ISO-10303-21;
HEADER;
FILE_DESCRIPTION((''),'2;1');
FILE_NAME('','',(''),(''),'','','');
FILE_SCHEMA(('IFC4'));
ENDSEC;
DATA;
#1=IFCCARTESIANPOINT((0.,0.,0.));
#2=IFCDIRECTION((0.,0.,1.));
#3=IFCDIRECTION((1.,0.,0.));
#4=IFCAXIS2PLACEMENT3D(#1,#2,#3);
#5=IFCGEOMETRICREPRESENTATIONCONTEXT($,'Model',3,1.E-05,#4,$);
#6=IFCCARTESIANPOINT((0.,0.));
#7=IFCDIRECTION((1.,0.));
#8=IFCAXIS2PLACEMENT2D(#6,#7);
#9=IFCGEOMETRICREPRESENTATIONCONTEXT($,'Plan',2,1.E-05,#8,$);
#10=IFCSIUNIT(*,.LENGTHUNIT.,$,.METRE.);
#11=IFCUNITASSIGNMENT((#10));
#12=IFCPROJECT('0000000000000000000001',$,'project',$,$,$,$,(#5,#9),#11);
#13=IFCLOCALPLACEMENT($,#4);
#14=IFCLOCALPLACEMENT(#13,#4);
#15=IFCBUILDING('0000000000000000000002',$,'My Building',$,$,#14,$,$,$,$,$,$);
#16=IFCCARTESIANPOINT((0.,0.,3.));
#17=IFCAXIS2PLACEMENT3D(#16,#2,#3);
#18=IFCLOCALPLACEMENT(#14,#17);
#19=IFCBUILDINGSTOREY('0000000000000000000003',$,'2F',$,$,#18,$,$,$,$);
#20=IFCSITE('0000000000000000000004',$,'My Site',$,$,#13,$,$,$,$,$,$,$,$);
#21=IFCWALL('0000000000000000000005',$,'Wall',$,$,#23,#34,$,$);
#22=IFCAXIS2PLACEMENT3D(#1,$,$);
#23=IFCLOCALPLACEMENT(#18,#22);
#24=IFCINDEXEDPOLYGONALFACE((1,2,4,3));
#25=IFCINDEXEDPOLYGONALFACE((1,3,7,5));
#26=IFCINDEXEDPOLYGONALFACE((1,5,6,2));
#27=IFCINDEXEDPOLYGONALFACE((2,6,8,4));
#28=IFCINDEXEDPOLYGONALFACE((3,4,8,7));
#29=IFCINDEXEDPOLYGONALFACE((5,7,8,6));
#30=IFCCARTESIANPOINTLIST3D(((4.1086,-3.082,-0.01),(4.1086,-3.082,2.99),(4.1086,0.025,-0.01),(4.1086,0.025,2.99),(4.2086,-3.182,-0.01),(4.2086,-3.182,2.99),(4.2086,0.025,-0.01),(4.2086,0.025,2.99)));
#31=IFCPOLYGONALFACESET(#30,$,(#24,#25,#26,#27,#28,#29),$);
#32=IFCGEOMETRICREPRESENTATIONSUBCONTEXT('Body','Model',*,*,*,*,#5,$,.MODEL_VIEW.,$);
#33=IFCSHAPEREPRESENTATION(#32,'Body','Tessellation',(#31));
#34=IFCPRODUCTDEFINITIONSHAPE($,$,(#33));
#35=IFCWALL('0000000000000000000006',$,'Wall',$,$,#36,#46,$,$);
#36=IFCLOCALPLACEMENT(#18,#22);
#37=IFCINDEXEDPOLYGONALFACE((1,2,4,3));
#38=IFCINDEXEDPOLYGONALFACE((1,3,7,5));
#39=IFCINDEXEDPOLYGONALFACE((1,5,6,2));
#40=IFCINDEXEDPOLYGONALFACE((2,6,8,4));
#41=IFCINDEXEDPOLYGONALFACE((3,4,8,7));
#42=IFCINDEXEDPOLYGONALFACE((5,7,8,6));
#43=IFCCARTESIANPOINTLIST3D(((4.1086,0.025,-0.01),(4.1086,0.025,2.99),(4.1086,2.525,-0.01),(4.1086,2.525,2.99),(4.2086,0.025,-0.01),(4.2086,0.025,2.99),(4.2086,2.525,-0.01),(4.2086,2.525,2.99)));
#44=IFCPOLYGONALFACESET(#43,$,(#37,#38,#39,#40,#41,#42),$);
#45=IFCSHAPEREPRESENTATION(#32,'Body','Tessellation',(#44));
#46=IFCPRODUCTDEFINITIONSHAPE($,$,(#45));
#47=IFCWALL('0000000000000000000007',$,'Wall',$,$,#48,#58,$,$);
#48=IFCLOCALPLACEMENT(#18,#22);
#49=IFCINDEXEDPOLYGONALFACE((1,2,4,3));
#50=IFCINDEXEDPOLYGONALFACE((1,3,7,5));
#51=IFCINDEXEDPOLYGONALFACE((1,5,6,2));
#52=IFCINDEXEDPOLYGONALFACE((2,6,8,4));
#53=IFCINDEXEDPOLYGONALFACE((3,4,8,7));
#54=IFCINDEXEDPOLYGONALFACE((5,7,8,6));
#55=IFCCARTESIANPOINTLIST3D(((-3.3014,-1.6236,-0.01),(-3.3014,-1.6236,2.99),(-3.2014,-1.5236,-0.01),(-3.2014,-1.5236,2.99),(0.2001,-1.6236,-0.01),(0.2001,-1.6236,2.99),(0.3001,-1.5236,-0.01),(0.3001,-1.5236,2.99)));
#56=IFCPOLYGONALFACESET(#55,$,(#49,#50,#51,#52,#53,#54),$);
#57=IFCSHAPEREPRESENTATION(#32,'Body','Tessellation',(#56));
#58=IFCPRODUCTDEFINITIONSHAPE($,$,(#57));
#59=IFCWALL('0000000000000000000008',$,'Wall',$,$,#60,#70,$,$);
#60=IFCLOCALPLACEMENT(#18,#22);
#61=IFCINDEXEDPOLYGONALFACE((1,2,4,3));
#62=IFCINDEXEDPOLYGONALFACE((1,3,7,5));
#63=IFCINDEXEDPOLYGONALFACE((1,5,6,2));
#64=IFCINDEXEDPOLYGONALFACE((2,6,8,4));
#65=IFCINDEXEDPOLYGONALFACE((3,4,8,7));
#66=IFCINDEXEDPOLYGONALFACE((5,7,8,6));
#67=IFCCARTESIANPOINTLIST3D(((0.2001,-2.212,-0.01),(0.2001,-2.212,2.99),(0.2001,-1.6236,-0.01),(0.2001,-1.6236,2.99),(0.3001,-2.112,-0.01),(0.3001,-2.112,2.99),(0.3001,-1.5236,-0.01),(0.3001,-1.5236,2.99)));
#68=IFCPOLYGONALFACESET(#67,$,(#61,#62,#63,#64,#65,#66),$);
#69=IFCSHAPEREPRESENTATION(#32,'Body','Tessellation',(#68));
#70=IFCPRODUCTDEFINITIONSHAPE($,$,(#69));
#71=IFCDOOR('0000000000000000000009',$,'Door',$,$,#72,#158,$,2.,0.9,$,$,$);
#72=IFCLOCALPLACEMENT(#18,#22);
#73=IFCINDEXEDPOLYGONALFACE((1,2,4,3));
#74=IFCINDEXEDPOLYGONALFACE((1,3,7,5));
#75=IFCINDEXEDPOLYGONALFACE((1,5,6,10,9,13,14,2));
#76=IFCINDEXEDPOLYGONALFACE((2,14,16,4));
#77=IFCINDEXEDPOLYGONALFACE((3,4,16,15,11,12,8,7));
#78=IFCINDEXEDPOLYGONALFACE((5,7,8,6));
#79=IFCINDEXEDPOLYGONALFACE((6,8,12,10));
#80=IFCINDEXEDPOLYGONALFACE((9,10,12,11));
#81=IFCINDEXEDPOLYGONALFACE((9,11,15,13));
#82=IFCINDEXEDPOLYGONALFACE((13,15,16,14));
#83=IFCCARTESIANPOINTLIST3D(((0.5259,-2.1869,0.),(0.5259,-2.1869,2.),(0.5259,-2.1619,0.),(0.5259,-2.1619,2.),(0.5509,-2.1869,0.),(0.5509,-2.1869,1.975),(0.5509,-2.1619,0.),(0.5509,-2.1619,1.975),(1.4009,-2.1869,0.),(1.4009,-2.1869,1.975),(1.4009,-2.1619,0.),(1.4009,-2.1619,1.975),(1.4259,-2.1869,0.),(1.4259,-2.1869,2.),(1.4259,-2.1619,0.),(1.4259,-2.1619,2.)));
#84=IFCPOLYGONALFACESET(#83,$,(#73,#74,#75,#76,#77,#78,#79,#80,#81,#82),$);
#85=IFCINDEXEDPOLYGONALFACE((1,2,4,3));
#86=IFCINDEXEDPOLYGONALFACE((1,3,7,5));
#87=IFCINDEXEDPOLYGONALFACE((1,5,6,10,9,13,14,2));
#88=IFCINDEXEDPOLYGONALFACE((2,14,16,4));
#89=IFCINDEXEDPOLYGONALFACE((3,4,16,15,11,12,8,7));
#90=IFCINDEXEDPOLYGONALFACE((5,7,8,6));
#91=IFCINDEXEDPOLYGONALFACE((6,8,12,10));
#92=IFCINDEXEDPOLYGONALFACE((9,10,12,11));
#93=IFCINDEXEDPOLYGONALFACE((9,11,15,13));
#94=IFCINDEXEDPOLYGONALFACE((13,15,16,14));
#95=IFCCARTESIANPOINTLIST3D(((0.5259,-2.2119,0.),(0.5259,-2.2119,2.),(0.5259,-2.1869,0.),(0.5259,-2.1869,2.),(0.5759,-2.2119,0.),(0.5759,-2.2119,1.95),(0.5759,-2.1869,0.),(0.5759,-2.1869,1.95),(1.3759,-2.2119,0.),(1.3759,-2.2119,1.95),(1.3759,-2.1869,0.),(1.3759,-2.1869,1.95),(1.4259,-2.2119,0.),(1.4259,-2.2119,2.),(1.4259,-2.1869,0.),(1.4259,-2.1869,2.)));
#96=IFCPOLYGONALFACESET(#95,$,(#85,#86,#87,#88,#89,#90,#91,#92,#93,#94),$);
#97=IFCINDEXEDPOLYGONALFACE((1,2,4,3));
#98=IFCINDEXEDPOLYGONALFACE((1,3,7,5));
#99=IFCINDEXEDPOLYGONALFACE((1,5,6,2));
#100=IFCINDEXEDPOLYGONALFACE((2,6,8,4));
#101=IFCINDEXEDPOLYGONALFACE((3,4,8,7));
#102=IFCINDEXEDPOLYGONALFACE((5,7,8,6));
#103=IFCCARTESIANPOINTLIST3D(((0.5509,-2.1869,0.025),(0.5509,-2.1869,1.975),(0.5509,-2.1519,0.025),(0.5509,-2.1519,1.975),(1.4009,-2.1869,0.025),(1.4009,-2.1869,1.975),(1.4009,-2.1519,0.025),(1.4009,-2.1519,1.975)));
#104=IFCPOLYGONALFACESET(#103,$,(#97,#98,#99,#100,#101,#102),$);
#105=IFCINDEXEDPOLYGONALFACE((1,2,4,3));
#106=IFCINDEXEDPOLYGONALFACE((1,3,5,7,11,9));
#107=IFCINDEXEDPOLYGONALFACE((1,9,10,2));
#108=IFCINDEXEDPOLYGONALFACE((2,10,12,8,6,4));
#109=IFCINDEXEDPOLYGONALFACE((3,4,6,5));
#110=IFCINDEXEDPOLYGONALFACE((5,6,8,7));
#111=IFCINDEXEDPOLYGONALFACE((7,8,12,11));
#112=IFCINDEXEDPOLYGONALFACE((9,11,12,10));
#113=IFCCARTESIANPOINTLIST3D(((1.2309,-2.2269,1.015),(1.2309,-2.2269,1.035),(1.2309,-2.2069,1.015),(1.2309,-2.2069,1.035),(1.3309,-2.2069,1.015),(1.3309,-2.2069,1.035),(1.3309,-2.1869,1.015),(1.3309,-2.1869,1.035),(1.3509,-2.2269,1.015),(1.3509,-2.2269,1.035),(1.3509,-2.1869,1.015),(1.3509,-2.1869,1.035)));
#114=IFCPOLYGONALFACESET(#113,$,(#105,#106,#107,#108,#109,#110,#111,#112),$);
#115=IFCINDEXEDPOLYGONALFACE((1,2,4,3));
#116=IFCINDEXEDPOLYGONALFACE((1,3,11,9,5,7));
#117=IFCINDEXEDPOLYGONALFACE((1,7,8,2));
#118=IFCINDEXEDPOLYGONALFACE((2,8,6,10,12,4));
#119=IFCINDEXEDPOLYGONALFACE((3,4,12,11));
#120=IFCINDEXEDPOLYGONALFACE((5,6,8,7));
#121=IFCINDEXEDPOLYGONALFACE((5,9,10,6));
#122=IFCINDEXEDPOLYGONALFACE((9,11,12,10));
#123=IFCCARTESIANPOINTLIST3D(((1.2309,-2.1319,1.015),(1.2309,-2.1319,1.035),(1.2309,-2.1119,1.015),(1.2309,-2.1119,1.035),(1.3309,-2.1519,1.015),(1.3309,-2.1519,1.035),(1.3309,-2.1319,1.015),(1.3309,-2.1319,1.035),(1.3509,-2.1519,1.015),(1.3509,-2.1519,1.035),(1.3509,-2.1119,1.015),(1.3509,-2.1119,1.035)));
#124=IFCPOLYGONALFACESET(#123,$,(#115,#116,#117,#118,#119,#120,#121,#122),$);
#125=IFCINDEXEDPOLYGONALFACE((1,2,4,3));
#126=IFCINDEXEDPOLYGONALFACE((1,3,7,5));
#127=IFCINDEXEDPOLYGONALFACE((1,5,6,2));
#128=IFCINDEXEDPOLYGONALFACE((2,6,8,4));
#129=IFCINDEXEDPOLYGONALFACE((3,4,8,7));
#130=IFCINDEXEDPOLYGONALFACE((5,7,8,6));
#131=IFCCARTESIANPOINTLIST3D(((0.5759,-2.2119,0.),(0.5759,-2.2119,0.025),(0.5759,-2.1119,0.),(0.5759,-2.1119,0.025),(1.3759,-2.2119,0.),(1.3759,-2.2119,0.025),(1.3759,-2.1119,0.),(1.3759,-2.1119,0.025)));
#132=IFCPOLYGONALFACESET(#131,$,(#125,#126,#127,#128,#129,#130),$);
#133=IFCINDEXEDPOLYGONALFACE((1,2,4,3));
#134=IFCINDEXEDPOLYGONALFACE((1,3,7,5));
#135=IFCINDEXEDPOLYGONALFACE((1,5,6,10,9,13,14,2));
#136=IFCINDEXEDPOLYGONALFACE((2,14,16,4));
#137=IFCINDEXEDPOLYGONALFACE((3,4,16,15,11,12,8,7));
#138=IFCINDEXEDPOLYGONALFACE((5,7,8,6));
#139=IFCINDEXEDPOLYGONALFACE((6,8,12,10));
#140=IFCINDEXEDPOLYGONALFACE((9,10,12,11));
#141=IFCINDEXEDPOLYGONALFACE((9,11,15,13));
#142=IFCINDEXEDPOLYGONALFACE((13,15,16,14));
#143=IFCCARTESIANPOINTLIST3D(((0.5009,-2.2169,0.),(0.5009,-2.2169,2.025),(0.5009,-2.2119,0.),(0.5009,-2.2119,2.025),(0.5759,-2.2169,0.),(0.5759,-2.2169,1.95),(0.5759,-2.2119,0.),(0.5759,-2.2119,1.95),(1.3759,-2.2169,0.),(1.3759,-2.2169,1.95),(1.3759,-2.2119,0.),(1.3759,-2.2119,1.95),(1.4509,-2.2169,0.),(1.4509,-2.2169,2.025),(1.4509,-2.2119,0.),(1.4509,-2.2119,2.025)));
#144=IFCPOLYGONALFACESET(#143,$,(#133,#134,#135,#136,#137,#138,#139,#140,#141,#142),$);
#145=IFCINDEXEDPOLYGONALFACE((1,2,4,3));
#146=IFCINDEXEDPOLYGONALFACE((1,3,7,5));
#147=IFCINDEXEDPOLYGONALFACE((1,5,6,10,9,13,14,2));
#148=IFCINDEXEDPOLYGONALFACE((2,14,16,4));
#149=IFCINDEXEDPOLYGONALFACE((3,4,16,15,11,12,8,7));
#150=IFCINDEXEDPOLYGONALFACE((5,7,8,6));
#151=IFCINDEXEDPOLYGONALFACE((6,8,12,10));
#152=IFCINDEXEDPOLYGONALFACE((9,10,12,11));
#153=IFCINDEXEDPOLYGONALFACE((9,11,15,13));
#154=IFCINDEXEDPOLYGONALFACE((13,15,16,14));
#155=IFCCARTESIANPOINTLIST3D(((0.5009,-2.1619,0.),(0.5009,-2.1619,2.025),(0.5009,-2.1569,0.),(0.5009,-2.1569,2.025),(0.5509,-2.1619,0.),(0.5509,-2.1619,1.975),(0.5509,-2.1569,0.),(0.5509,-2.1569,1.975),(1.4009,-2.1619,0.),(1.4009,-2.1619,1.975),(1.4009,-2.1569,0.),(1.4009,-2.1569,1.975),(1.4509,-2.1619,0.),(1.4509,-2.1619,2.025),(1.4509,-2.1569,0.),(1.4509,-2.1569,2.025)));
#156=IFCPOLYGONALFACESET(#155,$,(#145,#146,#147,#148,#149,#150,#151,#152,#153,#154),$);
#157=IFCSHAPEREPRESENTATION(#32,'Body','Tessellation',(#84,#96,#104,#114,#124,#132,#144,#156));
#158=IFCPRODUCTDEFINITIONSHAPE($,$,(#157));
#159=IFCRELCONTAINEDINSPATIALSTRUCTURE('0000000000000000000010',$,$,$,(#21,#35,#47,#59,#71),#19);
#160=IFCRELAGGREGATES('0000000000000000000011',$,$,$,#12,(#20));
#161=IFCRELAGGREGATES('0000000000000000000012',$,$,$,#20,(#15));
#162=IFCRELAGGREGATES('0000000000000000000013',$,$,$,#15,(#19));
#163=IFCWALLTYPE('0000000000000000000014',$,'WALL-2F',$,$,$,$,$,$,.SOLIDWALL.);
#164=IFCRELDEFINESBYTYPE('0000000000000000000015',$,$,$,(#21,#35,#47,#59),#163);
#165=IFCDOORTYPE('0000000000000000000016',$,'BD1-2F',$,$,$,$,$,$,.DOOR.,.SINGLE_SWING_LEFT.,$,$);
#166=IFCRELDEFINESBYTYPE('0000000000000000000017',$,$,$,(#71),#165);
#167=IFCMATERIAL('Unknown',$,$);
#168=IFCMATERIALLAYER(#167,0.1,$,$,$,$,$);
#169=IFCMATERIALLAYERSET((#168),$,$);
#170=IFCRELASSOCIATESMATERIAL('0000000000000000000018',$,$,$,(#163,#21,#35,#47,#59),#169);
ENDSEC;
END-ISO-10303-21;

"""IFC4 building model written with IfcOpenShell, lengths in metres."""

from ifc_helpers import new_model, entity, si_unit, frame, origin_with_axes, origin_2d_with_axis, place, context, subcontext, project, spatial, line, indexed_curve, outline, extrude, shape, source, transform, mapped, material, layer, layer_set, layer_usage, type_object, type_shapes, element, save


model = new_model("IFC4")

# Units and contexts
model_context = context("Model", 3, precision=1e-05, world=origin_with_axes())
plan_context = context("Plan", 2, precision=1e-05, world=origin_2d_with_axis())
body_context_1 = subcontext(model_context, "Body", "Model", "MODEL_VIEW")
body_context_2 = subcontext(plan_context, "Body", "Plan", "PLAN_VIEW")
ifc_project = project(units=[si_unit("LENGTHUNIT", "METRE")], contexts=[model_context, plan_context])

# Site, building, storey
site_placement = place(None, origin_with_axes())
site = spatial("IfcSite", under=ifc_project, at=site_placement, Name="My Site")
building_placement = place(site_placement, origin_with_axes())
building = spatial("IfcBuilding", under=site, at=building_placement, Name="My Building")
storey_placement = place(building_placement, frame((0.0, 0.0, 3.0), z_axis=(0.0, 0.0, 1.0), x_axis=(1.0, 0.0, 0.0)))
storey = spatial("IfcBuildingStorey", under=building, at=storey_placement, Name="2F")

# Shared definitions
ifc_material_1 = material(Name="Unknown")

# Shared definitions
ifc_layer_1 = layer(ifc_material_1, 0.1)
ifc_layer_set_1 = layer_set([ifc_layer_1])
wall_type = type_object("IfcWallType", Name="WALL-2F", PredefinedType="SOLIDWALL", material=ifc_layer_set_1)

# Walls
ifc_layer_usage_1 = layer_usage(ifc_layer_set_1, "AXIS2", "POSITIVE", 0.0)
wall_1_placement = place(storey_placement, frame((4.2086, -3.182, -0.01), z_axis=(0.0, 0.0, 1.0), x_axis=(0.0, 1.0, 0.0)))
element("IfcWall", 1, at=wall_1_placement, inside=storey, type_object=wall_type, material=ifc_layer_usage_1, Name="Wall", context=body_context_1, shape_type="SweptSolid", body=[
    extrude(outline(indexed_curve([(0.0, 0.0), (0.1, 0.1), (3.207, 0.1), (3.207, 0.0)], segments=[line(1, 2, 3, 4, 1)])), origin_with_axes(), (0.0, 0.0, 1.0), 3.0),
])
ifc_layer_usage_2 = layer_usage(ifc_layer_set_1, "AXIS2", "POSITIVE", 0.0)
wall_2_placement = place(storey_placement, frame((4.2086, 0.025, -0.01), z_axis=(0.0, 0.0, 1.0), x_axis=(0.0, 1.0, 0.0)))
element("IfcWall", 2, at=wall_2_placement, inside=storey, type_object=wall_type, material=ifc_layer_usage_2, Name="Wall", context=body_context_1, shape_type="SweptSolid", body=[
    extrude(outline(indexed_curve([(0.0, 0.0), (0.0, 0.1), (2.5, 0.1), (2.5, 0.0)], segments=[line(1, 2, 3, 4, 1)])), origin_with_axes(), (0.0, 0.0, 1.0), 3.0),
])
ifc_layer_usage_3 = layer_usage(ifc_layer_set_1, "AXIS2", "POSITIVE", 0.0)
wall_3_placement = place(storey_placement, frame((-3.3014, -1.6236, -0.01), z_axis=(0.0, 0.0, 1.0), x_axis=(1.0, 0.0, 0.0)))
element("IfcWall", 3, at=wall_3_placement, inside=storey, type_object=wall_type, material=ifc_layer_usage_3, Name="Wall", context=body_context_1, shape_type="SweptSolid", body=[
    extrude(outline(indexed_curve([(0.0, 0.0), (0.1, 0.1), (3.6015, 0.1), (3.5015, 0.0)], segments=[line(1, 2, 3, 4, 1)])), origin_with_axes(), (0.0, 0.0, 1.0), 3.0),
])
ifc_layer_usage_4 = layer_usage(ifc_layer_set_1, "AXIS2", "POSITIVE", 0.0)
wall_4_placement = place(storey_placement, frame((0.2001, -1.6236, -0.01), z_axis=(0.0, 0.0, 1.0), x_axis=(0.0, -1.0, 0.0)))
element("IfcWall", 4, at=wall_4_placement, inside=storey, type_object=wall_type, material=ifc_layer_usage_4, Name="Wall", context=body_context_1, shape_type="SweptSolid", body=[
    extrude(outline(indexed_curve([(0.0, 0.0), (-0.1, 0.1), (0.4884, 0.1), (0.5884, 0.0)], segments=[line(1, 2, 3, 4, 1)])), origin_with_axes(), (0.0, 0.0, 1.0), 3.0),
])

# Door
door_type_1 = type_object("IfcDoorType", Name="BD1-2F", OperationType="SINGLE_SWING_LEFT", PredefinedType="DOOR")
shared_shape_1 = source(origin_with_axes(), body_context_1, "Body", "SweptSolid", [
    extrude(outline(indexed_curve([(0.0, 0.0), (0.0, 2.0), (0.9, 2.0), (0.9, 0.0), (0.875, 0.0), (0.875, 1.975), (0.025, 1.975), (0.025, 0.0)], segments=[line(1, 2, 3, 4, 5, 6, 7, 8, 1)])), frame((0.0, 0.025, 0.0), z_axis=(0.0, -1.0, 0.0), x_axis=(1.0, 0.0, 0.0)), (0.0, 0.0, -1.0), 0.025),
    extrude(outline(indexed_curve([(0.0, 0.0), (0.0, 2.0), (0.9, 2.0), (0.9, 0.0), (0.85, 0.0), (0.85, 1.95), (0.05, 1.95), (0.05, 0.0)], segments=[line(1, 2, 3, 4, 5, 6, 7, 8, 1)])), frame((0.0, 0.0, 0.0), z_axis=(0.0, -1.0, 0.0), x_axis=(1.0, 0.0, 0.0)), (0.0, 0.0, -1.0), 0.025),
    extrude(outline(indexed_curve([(0.0, 0.0), (0.85, 0.0), (0.85, 0.035), (0.0, 0.035)], segments=[line(1, 2, 3, 4, 1)])), frame((0.025, 0.025, 0.025), z_axis=(0.0, 0.0, 1.0), x_axis=(1.0, 0.0, 0.0)), (0.0, 0.0, 1.0), 1.95),
    extrude(outline(indexed_curve([(0.0, 0.0), (0.0, -0.04), (-0.12, -0.04), (-0.12, -0.02), (-0.02, -0.02), (-0.02, 0.0)], segments=[line(1, 2, 3, 4, 5, 6, 1)])), frame((0.825, 0.025, 1.015), z_axis=(0.0, 0.0, 1.0), x_axis=(1.0, 0.0, 0.0)), (0.0, 0.0, 1.0), 0.02),
    extrude(outline(indexed_curve([(0.0, 0.0), (0.0, 0.04), (-0.12, 0.04), (-0.12, 0.02), (-0.02, 0.02), (-0.02, 0.0)], segments=[line(1, 2, 3, 4, 5, 6, 1)])), frame((0.825, 0.06, 1.015), z_axis=(0.0, 0.0, 1.0), x_axis=(1.0, 0.0, 0.0)), (0.0, 0.0, 1.0), 0.02),
    extrude(outline(indexed_curve([(0.0, 0.0), (0.8, 0.0), (0.8, 0.1), (0.0, 0.1)], segments=[line(1, 2, 3, 4, 1)])), frame((0.05, 0.0, 0.0), z_axis=(0.0, 0.0, 1.0), x_axis=(1.0, 0.0, 0.0)), (0.0, 0.0, 1.0), 0.025),
    extrude(outline(indexed_curve([(0.0, 0.0), (0.0, 2.025), (0.95, 2.025), (0.95, 0.0), (0.875, 0.0), (0.875, 1.95), (0.075, 1.95), (0.075, 0.0)], segments=[line(1, 2, 3, 4, 5, 6, 7, 8, 1)])), frame((-0.025, -0.005, 0.0), z_axis=(0.0, -1.0, 0.0), x_axis=(1.0, 0.0, 0.0)), (0.0, 0.0, -1.0), 0.005),
    extrude(outline(indexed_curve([(0.0, 0.0), (0.0, 2.025), (0.95, 2.025), (0.95, 0.0), (0.9, 0.0), (0.9, 1.975), (0.05, 1.975), (0.05, 0.0)], segments=[line(1, 2, 3, 4, 5, 6, 7, 8, 1)])), frame((-0.025, 0.05, 0.0), z_axis=(0.0, -1.0, 0.0), x_axis=(1.0, 0.0, 0.0)), (0.0, 0.0, -1.0), 0.005),
])
shared_shape_2 = source(origin_with_axes(), body_context_2, "Body", "Curve2D", [
    entity("IfcIndexedPolyCurve", entity("IfcCartesianPointList2D", [[0.0, 0.0], [0.0, 0.05], [0.025, 0.05], [0.025, 0.025], [0.05, 0.025], [0.05, 0.0]]), [entity("IfcLineIndex", [1, 2, 3, 4, 5, 6, 1])]),
    entity("IfcIndexedPolyCurve", entity("IfcCartesianPointList2D", [[0.9, 0.0], [0.9, 0.05], [0.875, 0.05], [0.875, 0.025], [0.85, 0.025], [0.85, 0.0]]), [entity("IfcLineIndex", [1, 2, 3, 4, 5, 6, 1])]),
    entity("IfcTrimmedCurve", entity("IfcEllipse", entity("IfcAxis2Placement2D", entity("IfcCartesianPoint", [0.06, 0.05]), entity("IfcDirection", [1.0, 0.0])), 0.815, 0.85), [entity("IfcCartesianPoint", [0.875, 0.05])], [entity("IfcCartesianPoint", [0.06, 0.9])], True, "CARTESIAN"),
    entity("IfcIndexedPolyCurve", entity("IfcCartesianPointList2D", [[0.025, 0.05], [0.06, 0.05], [0.06, 0.9], [0.025, 0.9]]), [entity("IfcLineIndex", [1, 2, 3, 4, 1])]),
])
type_shapes(door_type_1, [shared_shape_1, shared_shape_2])
door_1_placement = place(storey_placement, frame((0.5259, -2.2119, 0.0), z_axis=(0.0, 0.0, 1.0), x_axis=(1.0, 0.0, 0.0)))
element("IfcDoor", 5, at=door_1_placement, inside=storey, type_object=door_type_1, Name="Door", OverallHeight=2.0, OverallWidth=0.9, shapes=[
    shape(body_context_1, "Body", "MappedRepresentation", [mapped(shared_shape_1, transform((0.0, 0.0, 0.0), x_axis=(1.0, 0.0, 0.0), y_axis=(0.0, 1.0, 0.0), z_axis=(0.0, 0.0, 1.0), scale=1.0))]),
    shape(body_context_2, "Body", "MappedRepresentation", [mapped(shared_shape_2, transform((0.0, 0.0, 0.0), x_axis=(1.0, 0.0, 0.0), y_axis=(0.0, 1.0, 0.0), z_axis=(0.0, 0.0, 1.0), scale=1.0))]),
])

save(model, "model.ifc")
